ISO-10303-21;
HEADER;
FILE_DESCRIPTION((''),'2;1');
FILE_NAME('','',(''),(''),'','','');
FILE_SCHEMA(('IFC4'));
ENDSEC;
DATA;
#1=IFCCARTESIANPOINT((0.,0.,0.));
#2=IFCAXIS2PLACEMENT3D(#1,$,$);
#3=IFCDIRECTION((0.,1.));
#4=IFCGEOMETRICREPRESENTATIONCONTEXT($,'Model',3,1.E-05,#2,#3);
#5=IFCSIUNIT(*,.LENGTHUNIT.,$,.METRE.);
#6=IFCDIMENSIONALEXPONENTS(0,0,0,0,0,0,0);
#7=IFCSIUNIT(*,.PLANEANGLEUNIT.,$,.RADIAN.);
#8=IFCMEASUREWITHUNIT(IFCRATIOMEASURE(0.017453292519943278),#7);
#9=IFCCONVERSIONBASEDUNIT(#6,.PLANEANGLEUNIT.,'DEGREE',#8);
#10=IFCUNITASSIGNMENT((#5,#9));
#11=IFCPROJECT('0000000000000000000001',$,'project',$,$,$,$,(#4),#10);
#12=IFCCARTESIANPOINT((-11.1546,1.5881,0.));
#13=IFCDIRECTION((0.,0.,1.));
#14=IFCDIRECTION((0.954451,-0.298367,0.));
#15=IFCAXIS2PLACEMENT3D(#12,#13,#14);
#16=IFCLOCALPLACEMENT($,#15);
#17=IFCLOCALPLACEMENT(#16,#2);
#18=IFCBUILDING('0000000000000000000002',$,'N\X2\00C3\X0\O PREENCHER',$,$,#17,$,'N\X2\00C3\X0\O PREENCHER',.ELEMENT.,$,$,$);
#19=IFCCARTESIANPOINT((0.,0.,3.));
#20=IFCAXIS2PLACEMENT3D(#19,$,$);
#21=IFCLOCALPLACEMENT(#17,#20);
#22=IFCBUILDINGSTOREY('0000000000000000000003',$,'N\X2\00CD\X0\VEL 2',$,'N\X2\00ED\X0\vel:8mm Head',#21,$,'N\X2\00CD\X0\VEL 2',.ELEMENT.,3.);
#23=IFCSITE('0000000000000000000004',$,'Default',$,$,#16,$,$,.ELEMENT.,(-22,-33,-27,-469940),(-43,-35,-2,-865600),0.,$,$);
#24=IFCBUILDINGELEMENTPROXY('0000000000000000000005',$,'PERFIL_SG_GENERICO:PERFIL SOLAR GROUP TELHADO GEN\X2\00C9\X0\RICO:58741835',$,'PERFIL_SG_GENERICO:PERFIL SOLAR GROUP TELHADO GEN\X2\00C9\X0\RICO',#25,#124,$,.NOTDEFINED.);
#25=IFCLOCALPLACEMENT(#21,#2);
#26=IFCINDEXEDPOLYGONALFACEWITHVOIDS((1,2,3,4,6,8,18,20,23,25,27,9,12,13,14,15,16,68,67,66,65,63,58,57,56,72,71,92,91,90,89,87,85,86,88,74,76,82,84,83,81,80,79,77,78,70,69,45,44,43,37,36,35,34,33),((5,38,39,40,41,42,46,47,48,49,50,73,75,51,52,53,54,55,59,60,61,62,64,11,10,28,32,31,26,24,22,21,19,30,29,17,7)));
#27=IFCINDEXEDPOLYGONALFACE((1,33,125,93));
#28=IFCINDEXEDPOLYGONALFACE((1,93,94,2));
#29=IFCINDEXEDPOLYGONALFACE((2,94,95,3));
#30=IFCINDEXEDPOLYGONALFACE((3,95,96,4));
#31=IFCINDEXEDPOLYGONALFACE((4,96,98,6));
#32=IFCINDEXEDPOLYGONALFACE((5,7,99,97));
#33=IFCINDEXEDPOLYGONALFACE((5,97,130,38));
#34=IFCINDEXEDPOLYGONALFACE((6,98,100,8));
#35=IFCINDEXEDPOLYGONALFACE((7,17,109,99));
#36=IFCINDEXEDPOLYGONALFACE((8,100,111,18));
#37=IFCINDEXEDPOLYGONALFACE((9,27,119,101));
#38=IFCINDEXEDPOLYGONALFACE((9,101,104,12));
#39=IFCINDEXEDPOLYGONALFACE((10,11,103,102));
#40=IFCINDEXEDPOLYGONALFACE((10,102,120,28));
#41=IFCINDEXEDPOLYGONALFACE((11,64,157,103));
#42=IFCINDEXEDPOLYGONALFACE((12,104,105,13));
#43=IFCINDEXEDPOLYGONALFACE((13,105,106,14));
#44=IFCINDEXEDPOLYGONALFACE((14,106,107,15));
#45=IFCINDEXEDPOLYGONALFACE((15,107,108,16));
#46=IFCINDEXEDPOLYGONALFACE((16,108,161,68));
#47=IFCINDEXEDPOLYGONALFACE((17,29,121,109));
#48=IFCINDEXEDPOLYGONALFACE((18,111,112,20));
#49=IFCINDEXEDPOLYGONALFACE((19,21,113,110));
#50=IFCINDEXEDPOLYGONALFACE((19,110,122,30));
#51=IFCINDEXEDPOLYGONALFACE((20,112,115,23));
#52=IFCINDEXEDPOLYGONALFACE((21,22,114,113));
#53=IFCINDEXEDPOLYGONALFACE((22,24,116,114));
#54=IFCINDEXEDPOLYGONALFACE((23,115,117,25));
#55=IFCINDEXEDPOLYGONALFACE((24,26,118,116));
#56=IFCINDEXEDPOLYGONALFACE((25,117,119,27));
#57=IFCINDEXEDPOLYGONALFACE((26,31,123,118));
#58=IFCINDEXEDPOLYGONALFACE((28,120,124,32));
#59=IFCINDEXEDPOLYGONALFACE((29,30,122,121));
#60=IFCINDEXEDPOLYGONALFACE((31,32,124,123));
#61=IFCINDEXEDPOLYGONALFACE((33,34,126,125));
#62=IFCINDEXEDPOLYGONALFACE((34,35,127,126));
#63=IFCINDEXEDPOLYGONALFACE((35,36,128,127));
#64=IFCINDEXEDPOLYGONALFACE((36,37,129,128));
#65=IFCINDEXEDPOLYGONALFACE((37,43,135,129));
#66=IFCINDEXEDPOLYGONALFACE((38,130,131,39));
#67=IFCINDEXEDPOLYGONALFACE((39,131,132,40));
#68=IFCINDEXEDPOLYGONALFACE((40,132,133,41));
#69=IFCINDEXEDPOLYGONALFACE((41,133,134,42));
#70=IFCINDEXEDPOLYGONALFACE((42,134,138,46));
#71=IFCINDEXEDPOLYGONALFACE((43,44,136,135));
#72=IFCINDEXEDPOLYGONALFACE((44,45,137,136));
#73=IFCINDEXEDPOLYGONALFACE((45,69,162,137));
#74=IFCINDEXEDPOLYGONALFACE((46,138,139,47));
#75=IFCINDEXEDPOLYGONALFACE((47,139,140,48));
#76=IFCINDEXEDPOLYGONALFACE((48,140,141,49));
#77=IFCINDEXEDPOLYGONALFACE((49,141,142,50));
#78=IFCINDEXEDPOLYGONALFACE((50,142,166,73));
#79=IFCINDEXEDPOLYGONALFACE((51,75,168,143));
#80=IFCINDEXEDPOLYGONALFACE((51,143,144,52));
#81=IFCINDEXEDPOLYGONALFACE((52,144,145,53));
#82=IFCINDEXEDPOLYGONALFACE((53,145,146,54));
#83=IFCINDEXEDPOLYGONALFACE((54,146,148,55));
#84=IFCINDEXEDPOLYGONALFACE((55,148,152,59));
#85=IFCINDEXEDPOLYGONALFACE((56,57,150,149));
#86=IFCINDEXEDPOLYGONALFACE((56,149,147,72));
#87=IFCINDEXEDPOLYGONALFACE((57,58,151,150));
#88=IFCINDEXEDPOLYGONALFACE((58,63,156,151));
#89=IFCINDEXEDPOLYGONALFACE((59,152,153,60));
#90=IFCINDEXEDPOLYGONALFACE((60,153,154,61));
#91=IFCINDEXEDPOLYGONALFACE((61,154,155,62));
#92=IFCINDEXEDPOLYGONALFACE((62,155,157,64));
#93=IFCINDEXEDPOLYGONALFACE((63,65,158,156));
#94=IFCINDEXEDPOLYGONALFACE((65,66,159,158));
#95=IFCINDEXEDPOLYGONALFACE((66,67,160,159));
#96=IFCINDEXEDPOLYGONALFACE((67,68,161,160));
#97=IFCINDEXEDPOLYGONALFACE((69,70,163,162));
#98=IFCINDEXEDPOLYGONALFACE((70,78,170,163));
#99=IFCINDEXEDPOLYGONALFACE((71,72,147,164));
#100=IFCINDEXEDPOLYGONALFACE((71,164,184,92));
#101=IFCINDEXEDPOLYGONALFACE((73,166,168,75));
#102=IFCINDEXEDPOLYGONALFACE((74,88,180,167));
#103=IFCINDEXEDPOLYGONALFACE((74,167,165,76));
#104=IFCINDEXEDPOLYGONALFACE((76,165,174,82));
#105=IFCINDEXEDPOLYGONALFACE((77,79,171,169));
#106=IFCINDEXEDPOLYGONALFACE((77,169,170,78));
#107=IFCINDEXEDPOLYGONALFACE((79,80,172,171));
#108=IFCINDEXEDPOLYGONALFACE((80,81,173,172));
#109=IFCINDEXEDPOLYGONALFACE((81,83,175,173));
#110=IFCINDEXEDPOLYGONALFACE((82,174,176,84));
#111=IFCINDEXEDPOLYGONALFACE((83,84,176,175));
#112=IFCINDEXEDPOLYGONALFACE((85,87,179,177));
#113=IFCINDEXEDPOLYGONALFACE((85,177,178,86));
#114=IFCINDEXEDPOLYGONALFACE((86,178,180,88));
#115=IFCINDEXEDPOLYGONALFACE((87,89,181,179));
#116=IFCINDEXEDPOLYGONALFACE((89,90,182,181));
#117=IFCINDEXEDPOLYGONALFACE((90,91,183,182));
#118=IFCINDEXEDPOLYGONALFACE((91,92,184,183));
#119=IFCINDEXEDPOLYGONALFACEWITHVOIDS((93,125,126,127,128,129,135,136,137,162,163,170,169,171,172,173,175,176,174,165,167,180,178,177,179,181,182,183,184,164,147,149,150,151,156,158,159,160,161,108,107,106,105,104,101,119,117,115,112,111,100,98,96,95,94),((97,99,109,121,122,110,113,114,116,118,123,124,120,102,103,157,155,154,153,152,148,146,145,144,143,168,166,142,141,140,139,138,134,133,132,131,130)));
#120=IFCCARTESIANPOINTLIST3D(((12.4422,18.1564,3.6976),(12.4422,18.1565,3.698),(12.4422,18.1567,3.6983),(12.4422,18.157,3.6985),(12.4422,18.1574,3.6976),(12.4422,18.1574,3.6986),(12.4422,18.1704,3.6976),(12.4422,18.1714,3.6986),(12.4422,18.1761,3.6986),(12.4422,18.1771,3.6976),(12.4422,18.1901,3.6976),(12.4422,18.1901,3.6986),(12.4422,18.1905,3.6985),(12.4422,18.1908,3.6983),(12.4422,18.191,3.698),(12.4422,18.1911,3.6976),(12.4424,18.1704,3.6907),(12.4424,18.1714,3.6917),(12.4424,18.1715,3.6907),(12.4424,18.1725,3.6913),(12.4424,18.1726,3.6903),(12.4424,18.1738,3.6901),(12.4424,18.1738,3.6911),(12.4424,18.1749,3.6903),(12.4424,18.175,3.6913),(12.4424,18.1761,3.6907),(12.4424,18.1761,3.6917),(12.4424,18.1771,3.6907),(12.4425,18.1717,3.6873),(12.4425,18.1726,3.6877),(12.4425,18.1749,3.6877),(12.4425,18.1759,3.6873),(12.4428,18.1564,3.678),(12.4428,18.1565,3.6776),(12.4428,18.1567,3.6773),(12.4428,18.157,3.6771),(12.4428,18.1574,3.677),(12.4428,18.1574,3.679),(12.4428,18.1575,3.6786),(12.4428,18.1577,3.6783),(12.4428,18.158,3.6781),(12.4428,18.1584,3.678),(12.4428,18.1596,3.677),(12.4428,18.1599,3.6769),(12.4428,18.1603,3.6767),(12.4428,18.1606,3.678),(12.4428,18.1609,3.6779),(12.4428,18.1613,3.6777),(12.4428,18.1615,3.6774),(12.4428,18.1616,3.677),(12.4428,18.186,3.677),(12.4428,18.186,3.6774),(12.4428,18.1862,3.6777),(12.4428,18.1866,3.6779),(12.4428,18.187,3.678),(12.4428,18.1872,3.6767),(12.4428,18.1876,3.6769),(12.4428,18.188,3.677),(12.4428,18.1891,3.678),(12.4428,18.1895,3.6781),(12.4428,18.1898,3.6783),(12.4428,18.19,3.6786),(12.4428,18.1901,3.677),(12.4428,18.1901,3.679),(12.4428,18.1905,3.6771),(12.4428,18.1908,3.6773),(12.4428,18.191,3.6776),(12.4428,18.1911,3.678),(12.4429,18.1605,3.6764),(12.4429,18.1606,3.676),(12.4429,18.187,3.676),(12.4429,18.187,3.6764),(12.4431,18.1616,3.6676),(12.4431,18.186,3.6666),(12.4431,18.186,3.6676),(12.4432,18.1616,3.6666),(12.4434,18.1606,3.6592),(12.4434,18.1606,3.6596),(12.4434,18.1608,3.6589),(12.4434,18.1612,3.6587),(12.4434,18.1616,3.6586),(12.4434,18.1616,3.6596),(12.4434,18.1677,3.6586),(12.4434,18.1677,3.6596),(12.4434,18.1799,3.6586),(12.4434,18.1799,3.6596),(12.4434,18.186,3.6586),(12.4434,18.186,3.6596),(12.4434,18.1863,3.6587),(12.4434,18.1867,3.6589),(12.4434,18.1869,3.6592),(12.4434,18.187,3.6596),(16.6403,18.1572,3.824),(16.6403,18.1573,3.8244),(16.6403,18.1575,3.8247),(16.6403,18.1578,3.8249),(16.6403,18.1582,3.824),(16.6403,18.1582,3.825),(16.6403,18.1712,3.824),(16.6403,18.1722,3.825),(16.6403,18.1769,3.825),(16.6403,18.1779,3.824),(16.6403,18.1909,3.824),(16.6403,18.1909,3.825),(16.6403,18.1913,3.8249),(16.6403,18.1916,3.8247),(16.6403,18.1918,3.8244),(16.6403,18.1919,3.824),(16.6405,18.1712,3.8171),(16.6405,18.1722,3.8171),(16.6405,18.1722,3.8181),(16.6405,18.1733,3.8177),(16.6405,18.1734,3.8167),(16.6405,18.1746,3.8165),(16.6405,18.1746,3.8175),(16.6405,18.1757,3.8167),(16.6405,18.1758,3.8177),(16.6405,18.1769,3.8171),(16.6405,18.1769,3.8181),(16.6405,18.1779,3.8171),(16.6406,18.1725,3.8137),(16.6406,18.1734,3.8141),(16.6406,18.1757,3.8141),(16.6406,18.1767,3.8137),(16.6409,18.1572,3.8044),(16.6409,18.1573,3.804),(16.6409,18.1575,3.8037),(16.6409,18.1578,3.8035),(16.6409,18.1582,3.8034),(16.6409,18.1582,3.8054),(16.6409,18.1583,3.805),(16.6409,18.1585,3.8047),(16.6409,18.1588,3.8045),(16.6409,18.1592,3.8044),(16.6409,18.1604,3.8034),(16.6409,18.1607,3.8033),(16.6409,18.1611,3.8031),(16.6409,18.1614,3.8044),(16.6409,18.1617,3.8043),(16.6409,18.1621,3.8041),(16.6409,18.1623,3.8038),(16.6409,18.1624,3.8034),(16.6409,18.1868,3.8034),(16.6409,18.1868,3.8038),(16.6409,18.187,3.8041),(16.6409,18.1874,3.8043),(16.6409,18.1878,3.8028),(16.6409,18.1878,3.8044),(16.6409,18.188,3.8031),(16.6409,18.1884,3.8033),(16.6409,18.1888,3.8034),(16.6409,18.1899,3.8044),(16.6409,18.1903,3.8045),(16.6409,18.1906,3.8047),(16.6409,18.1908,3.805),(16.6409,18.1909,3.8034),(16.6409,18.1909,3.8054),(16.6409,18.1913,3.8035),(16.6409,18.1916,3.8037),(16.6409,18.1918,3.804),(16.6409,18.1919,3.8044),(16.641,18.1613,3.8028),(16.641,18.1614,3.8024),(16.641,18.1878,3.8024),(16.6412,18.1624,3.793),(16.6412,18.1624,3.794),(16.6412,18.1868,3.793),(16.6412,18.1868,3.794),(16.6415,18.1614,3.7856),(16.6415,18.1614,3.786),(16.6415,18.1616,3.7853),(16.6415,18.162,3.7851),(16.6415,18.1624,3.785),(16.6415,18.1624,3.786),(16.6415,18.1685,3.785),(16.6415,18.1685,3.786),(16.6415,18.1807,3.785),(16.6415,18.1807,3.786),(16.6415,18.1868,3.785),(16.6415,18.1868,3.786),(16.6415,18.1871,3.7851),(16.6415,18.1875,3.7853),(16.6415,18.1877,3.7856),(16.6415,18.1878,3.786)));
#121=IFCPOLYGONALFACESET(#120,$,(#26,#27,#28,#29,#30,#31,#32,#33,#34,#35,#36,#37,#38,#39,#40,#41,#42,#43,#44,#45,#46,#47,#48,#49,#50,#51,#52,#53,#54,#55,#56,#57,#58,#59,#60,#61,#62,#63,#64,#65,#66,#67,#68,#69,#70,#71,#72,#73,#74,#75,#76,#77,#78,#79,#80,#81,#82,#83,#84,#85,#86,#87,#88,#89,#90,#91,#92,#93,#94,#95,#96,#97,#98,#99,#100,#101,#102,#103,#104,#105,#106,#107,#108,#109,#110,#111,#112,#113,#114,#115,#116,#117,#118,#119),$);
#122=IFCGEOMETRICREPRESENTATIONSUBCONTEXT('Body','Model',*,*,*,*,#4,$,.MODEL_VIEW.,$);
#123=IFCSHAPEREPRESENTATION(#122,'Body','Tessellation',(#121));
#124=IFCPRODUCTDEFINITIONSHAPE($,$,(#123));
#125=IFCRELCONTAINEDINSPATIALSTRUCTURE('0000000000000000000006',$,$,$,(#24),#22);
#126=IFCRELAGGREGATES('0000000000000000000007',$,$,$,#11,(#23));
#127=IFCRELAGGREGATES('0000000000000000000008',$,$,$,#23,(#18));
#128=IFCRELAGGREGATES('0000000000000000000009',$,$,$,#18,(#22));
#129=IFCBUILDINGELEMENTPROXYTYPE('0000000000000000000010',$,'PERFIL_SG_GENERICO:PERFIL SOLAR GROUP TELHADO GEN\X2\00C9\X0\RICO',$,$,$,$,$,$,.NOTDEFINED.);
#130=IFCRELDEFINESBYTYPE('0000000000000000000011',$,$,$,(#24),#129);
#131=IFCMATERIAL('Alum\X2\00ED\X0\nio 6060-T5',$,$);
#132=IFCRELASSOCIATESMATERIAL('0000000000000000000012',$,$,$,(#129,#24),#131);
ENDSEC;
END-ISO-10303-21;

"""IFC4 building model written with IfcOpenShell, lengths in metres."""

from ifc_helpers import new_model, entity, si_unit, converted_unit, direction, frame, origin, place, context, subcontext, project, spatial, line, arc, indexed_curve, outline, extrude, source, transform, mapped, material, type_object, type_shapes, element, save


model = new_model("IFC4")

# Units and contexts
model_context = context("Model", 3, precision=1e-05, world=origin(), true_north=direction((0.0, 1.0)))
body_context = subcontext(model_context, "Body", "Model", "MODEL_VIEW")
ifc_project = project(units=[si_unit("LENGTHUNIT", "METRE"), converted_unit("PLANEANGLEUNIT", "DEGREE", entity("IfcRatioMeasure", 0.017453292519943278), si_unit("PLANEANGLEUNIT", "RADIAN"), dimensions=[0, 0, 0, 0, 0, 0, 0])], contexts=[model_context])

# Site, building, storey
site_placement = place(None, frame((-11.1546, 1.5881, 0.0), z_axis=(0.0, 0.0, 1.0), x_axis=(0.954451, -0.298367, 0.0)))
site = spatial("IfcSite", under=ifc_project, at=site_placement, Name="Default", CompositionType="ELEMENT", RefLatitude=(-22, -33, -27, -469940), RefLongitude=(-43, -35, -2, -865600), RefElevation=0.0)
building_placement = place(site_placement, origin())
building = spatial("IfcBuilding", under=site, at=building_placement, Name="NÃO PREENCHER", LongName="NÃO PREENCHER", CompositionType="ELEMENT")
storey_placement = place(building_placement, frame((0.0, 0.0, 3.0)))
storey = spatial("IfcBuildingStorey", under=building, at=storey_placement, Name="NÍVEL 2", ObjectType="Nível:8mm Head", LongName="NÍVEL 2", CompositionType="ELEMENT", Elevation=3.0)

# Building element proxy
ifc_material_1 = material(Name="Alumínio 6060-T5")
building_element_proxy_type_1 = type_object("IfcBuildingElementProxyType", Name="PERFIL_SG_GENERICO:PERFIL SOLAR GROUP TELHADO GENÉRICO", PredefinedType="NOTDEFINED", material=ifc_material_1)
shared_shape_1 = source(origin(), body_context, "Body", "SweptSolid", [
    extrude(outline(indexed_curve([(-0.0122, -0.0169), (-0.0061, -0.0169), (-0.0061, -0.0159), (-0.0122, -0.0159), (-0.0122, -0.0089), (0.0122, -0.0089), (0.0122, -0.0159), (0.0061, -0.0159), (0.0061, -0.0169), (0.0122, -0.0169), (0.0129, -0.0166), (0.0132, -0.0159), (0.0132, 0.0005), (0.0135, 0.0012), (0.0142, 0.0015), (0.0164, 0.0015), (0.0171, 0.0018), (0.0174, 0.0025), (0.0174, 0.0221), (0.0171, 0.0228), (0.0164, 0.0231), (0.0024, 0.0231), (0.0024, 0.0162), (0.0, 0.0156), (-0.0024, 0.0162), (-0.0024, 0.0231), (-0.0164, 0.0231), (-0.0171, 0.0228), (-0.0174, 0.0221), (-0.0174, 0.0025), (-0.0171, 0.0018), (-0.0164, 0.0015), (-0.0142, 0.0015), (-0.0135, 0.0012), (-0.0132, 0.0005), (-0.0132, -0.0159), (-0.0129, -0.0166)], segments=[line(1, 2, 3, 4, 5, 6, 7, 8, 9, 10), arc(10, 11, 12), line(12, 13), arc(13, 14, 15), line(15, 16), arc(16, 17, 18), line(18, 19), arc(19, 20, 21), line(21, 22, 23), arc(23, 24, 25), line(25, 26, 27), arc(27, 28, 29), line(29, 30), arc(30, 31, 32), line(32, 33), arc(33, 34, 35), line(35, 36), arc(36, 37, 1)], self_intersect=False), holes=[indexed_curve([(-0.0122, -0.0079), (-0.0122, 0.0015), (-0.0125, 0.0022), (-0.0132, 0.0025), (-0.0154, 0.0025), (-0.0161, 0.0028), (-0.0164, 0.0035), (-0.0164, 0.0221), (-0.0034, 0.0221), (-0.0034, 0.0152), (-0.0021, 0.0118), (-0.0012, 0.0122), (-0.0023, 0.0151), (0.0, 0.0146), (0.0023, 0.0151), (0.0012, 0.0122), (0.0021, 0.0118), (0.0034, 0.0152), (0.0034, 0.0221), (0.0164, 0.0221), (0.0164, 0.0035), (0.0161, 0.0028), (0.0154, 0.0025), (0.0132, 0.0025), (0.0125, 0.0022), (0.0122, 0.0015), (0.0122, -0.0079)], segments=[line(1, 2), arc(2, 3, 4), line(4, 5), arc(5, 6, 7), line(7, 8, 9, 10, 11, 12, 13), arc(13, 14, 15), line(15, 16, 17, 18, 19, 20, 21), arc(21, 22, 23), line(23, 24), arc(24, 25, 26), line(26, 27, 1)], self_intersect=False)]), frame((0.0, 0.0, 0.0169), z_axis=(1.0, 0.0, 0.0), x_axis=(0.0, 1.0, 0.0)), (0.0, 0.0, 1.0), 4.2),
])
type_shapes(building_element_proxy_type_1, [shared_shape_1])
for number, where, z_axis, x_axis, name in (
    (1, (12.4434, 18.1738, 3.6586), (-0.030095, 0.0, 0.999547), (0.999547, 0.00019, 0.030095), "PERFIL_SG_GENERICO:PERFIL SOLAR GROUP TELHADO GENÉRICO:58741835"),
):
    element("IfcBuildingElementProxy", number, at=place(storey_placement, frame(where, z_axis=z_axis, x_axis=x_axis)), inside=storey, type_object=building_element_proxy_type_1, material=ifc_material_1, Name=name, ObjectType="PERFIL_SG_GENERICO:PERFIL SOLAR GROUP TELHADO GENÉRICO", PredefinedType="NOTDEFINED", context=body_context, shape_type="MappedRepresentation", body=[
        mapped(shared_shape_1, transform((0.0, 0.0, 0.0), scale=1.0)),
    ])

save(model, "model.ifc")
